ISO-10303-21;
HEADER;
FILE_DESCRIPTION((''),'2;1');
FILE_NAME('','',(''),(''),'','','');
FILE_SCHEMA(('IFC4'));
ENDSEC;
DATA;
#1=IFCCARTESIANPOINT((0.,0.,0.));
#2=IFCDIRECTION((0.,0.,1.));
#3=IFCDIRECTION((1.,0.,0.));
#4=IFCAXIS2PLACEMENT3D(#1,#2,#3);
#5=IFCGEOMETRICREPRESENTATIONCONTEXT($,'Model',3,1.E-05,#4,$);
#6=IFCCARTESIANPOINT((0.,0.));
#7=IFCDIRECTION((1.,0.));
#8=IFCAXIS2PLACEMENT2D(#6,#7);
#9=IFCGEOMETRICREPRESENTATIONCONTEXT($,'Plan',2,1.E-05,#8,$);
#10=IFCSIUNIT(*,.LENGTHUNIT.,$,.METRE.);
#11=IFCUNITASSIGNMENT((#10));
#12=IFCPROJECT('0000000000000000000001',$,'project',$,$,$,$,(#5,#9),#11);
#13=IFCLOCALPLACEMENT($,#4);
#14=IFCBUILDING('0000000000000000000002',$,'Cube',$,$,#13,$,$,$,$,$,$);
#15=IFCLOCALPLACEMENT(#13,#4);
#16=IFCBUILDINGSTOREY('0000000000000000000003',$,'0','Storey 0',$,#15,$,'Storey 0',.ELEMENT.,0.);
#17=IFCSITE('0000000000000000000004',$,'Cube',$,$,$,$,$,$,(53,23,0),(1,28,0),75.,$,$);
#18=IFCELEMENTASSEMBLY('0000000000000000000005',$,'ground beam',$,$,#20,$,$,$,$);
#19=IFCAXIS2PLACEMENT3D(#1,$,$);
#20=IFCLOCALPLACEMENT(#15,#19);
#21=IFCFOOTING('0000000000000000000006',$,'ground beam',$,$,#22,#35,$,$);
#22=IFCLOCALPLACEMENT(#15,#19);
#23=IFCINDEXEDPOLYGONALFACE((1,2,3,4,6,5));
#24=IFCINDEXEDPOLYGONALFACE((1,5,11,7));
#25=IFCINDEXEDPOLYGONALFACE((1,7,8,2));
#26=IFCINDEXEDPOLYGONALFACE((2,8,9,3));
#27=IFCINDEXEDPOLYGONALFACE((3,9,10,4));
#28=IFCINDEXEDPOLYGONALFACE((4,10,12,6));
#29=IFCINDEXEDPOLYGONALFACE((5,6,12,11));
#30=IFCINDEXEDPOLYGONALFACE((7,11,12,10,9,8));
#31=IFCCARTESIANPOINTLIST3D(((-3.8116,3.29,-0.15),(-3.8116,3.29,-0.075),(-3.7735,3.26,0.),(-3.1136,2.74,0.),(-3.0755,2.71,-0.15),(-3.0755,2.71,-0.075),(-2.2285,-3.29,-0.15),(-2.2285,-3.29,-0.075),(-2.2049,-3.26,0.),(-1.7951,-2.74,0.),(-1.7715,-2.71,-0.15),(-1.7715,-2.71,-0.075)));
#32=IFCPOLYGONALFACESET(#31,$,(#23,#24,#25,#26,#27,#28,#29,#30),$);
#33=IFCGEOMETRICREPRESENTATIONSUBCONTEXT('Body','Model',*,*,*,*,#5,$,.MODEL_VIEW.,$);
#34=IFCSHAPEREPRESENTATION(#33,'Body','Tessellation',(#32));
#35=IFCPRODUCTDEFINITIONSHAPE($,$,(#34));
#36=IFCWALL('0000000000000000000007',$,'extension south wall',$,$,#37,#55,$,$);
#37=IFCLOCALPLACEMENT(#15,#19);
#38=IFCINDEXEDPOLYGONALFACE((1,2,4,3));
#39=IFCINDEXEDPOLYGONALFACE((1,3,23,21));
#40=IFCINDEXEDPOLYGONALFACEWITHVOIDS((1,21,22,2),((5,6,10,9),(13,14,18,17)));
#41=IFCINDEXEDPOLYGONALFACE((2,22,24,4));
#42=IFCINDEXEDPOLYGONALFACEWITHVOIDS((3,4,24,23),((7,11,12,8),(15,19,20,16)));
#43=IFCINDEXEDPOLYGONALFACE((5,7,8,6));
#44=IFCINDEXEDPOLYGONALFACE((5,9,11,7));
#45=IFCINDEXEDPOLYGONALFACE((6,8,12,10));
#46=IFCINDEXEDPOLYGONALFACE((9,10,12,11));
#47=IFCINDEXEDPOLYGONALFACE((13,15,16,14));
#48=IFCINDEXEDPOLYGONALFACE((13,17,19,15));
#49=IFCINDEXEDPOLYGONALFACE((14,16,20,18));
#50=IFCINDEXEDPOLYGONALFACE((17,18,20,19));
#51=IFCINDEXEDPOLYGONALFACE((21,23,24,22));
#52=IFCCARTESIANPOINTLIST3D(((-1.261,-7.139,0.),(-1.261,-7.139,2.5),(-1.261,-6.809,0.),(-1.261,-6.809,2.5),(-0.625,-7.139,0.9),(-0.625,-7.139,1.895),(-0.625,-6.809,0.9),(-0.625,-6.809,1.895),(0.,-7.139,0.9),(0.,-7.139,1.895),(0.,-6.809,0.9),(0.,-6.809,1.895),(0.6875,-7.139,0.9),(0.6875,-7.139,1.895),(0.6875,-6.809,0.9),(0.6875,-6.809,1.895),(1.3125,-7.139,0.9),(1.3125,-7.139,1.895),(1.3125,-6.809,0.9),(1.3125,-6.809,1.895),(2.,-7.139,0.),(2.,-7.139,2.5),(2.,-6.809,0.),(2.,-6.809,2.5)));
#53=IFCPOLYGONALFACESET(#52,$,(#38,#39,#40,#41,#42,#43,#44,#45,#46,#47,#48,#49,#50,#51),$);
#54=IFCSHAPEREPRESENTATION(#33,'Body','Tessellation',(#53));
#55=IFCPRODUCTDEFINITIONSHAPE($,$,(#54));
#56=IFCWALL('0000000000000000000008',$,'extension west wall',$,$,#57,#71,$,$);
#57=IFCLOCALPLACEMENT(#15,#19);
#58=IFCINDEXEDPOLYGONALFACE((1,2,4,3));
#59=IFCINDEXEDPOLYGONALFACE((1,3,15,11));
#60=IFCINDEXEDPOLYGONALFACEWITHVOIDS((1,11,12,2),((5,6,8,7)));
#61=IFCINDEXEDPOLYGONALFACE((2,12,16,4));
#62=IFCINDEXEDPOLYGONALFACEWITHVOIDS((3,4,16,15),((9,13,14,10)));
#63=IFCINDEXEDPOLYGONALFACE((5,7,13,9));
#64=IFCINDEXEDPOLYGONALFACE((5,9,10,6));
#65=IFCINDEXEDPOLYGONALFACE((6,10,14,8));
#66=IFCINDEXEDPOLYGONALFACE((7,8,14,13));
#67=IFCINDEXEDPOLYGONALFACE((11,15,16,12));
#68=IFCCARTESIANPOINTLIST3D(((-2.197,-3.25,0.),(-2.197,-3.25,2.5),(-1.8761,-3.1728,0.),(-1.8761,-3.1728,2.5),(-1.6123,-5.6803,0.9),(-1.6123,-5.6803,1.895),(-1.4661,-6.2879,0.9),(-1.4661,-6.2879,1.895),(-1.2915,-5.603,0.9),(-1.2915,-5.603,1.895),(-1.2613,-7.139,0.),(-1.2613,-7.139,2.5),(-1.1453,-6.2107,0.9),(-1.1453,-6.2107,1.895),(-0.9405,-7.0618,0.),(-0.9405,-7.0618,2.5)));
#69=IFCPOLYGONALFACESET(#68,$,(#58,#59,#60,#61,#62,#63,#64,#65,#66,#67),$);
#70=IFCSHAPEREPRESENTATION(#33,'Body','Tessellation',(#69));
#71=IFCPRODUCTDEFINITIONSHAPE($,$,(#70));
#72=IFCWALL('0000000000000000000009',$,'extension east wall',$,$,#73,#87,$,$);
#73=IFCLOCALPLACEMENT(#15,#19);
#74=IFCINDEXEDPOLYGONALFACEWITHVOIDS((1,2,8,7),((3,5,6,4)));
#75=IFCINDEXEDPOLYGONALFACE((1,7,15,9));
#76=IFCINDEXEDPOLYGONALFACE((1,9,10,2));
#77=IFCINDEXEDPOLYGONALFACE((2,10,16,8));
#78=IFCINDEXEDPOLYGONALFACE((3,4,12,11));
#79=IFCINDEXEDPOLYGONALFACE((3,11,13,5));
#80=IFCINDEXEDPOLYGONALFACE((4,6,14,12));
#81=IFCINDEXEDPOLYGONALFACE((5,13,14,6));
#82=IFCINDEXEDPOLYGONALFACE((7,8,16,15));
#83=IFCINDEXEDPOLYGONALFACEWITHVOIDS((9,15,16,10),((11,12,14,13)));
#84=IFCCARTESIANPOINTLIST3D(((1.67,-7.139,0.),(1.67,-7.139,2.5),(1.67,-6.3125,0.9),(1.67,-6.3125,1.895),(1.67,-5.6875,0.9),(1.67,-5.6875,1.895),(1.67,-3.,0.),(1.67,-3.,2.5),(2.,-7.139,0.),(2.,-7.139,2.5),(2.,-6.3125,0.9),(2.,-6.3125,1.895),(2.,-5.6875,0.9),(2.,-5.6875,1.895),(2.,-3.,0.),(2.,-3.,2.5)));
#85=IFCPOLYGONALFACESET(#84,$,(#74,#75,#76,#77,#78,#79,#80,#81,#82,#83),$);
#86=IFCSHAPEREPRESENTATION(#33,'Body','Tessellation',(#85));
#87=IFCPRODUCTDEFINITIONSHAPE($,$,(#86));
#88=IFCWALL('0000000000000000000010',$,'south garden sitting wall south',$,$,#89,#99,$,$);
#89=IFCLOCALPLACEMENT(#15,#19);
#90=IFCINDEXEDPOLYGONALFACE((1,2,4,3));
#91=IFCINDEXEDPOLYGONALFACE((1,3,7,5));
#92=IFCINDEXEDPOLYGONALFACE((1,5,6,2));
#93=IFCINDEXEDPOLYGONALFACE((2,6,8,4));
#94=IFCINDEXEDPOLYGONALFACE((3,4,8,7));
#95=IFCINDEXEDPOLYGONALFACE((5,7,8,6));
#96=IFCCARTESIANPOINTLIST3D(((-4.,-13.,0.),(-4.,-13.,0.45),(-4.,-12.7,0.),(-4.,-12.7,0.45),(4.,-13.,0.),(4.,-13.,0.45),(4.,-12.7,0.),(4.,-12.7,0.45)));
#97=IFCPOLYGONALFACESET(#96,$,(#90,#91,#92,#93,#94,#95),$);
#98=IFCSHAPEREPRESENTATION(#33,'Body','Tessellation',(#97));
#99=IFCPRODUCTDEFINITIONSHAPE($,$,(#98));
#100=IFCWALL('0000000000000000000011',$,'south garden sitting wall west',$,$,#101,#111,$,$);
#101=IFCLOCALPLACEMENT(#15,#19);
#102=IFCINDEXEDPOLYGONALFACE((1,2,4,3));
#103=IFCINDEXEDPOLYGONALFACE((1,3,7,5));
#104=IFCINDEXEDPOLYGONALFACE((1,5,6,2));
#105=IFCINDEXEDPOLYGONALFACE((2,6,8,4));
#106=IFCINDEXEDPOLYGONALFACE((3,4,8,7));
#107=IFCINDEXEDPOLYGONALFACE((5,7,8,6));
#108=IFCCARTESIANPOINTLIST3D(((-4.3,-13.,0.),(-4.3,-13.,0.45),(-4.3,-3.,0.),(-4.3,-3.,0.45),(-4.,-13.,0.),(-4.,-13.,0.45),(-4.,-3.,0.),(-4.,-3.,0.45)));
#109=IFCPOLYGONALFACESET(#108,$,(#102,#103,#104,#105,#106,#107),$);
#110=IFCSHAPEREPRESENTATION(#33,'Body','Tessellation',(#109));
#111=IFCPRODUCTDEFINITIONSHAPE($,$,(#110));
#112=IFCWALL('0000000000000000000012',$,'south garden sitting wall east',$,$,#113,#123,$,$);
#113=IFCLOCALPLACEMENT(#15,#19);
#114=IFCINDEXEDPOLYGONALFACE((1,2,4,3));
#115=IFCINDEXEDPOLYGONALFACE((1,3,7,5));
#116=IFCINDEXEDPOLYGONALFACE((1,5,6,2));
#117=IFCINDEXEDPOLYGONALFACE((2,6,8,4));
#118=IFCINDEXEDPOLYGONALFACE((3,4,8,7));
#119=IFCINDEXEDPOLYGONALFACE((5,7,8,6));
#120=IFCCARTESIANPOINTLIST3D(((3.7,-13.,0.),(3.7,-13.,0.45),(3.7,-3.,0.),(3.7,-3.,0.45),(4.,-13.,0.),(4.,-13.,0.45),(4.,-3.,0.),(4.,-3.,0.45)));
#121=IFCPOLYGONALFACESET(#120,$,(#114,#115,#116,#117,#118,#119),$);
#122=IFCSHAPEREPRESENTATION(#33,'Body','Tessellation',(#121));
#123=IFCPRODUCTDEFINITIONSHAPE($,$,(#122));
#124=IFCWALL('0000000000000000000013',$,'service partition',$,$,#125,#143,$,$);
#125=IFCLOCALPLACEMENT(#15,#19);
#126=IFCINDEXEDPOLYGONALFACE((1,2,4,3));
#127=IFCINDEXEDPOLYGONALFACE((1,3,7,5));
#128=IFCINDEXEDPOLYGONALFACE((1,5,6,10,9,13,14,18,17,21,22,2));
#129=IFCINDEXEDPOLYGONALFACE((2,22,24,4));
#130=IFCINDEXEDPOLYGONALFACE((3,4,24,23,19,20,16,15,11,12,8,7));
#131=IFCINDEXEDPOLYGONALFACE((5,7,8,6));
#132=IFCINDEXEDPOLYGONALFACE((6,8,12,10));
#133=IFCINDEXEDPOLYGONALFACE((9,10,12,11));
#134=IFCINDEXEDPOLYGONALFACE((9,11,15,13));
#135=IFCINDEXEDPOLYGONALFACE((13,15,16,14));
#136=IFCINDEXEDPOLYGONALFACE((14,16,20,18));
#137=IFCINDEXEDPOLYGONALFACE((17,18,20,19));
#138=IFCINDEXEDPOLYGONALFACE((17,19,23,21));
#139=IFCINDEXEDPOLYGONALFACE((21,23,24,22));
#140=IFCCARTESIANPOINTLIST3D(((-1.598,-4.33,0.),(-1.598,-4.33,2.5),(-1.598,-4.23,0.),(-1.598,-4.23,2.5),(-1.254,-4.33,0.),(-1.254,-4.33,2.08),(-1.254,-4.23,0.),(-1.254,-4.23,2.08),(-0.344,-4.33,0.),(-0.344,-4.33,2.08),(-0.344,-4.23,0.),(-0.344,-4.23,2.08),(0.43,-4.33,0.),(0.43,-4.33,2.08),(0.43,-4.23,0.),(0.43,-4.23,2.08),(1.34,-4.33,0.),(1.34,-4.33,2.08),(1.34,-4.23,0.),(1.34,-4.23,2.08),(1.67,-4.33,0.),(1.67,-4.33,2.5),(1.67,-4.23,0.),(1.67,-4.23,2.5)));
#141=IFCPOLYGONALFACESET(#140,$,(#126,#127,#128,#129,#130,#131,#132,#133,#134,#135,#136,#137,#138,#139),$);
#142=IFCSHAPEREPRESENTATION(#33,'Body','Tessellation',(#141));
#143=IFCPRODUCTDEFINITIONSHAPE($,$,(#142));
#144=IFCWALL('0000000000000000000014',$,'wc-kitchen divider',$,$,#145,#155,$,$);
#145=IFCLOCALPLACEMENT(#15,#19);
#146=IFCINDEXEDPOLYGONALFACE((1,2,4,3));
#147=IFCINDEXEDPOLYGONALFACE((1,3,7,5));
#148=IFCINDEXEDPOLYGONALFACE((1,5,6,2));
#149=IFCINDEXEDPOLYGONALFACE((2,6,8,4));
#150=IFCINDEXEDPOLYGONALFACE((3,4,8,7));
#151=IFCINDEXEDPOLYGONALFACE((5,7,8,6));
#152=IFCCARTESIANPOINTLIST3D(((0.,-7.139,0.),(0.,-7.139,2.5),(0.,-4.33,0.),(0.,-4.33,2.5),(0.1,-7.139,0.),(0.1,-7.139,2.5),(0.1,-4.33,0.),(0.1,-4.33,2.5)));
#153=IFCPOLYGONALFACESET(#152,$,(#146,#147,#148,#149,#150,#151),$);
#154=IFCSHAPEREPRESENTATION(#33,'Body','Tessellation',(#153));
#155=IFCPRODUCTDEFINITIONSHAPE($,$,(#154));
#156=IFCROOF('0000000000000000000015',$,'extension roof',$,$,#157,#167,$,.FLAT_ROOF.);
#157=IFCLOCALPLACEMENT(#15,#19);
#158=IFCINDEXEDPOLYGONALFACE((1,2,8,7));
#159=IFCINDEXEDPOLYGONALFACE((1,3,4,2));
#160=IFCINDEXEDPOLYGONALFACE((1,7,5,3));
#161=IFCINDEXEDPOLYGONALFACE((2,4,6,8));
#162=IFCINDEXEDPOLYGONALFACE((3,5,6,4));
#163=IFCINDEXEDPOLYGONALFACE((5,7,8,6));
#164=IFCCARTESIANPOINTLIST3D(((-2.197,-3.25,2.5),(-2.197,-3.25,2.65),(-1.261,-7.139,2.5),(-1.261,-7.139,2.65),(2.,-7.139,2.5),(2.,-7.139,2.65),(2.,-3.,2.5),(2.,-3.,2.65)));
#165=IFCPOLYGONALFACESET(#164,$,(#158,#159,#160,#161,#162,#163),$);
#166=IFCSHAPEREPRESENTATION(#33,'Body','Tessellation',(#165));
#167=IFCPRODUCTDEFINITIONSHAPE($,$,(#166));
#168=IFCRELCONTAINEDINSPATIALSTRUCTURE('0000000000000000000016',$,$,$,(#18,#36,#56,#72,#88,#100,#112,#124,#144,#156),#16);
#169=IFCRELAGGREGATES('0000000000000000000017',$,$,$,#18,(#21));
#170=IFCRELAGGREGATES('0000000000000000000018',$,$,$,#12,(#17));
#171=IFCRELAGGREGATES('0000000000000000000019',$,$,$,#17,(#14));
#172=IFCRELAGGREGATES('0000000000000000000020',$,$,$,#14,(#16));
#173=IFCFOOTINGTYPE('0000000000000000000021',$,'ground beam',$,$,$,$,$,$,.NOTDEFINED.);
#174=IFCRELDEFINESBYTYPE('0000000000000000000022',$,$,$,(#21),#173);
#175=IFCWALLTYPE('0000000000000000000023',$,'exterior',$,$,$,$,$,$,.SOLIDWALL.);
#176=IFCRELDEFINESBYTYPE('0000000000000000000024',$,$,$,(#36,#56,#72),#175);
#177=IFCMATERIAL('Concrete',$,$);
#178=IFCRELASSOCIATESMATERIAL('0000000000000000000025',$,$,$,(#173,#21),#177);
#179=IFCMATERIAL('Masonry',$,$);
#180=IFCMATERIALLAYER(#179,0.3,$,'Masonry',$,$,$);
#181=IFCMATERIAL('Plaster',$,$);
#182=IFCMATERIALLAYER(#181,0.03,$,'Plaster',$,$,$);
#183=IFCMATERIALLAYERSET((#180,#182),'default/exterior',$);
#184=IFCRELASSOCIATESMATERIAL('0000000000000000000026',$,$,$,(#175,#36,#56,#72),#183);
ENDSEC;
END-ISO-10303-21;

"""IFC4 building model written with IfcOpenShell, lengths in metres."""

from ifc_helpers import new_model, si_unit, frame, origin_with_axes, origin_2d_with_axis, place, context, subcontext, project, spatial, polyline, indexed_curve, outline, extrude, clip, halfspace, material, layer, layer_set, layer_usage, material_profile, profile_set, profile_usage, type_object, element, aggregate, save


model = new_model("IFC4")

# Units and contexts
model_context = context("Model", 3, precision=1e-05, world=origin_with_axes())
plan_context = context("Plan", 2, precision=1e-05, world=origin_2d_with_axis())
body_context_1 = subcontext(model_context, "Body", "Model", "MODEL_VIEW")
ifc_project = project(units=[si_unit("LENGTHUNIT", "METRE")], contexts=[model_context, plan_context])

# Site, building, storey
site = spatial("IfcSite", under=ifc_project, Name="Cube", RefLatitude=(53, 23, 0), RefLongitude=(1, 28, 0), RefElevation=75.0)
building_placement = place(None, origin_with_axes())
building = spatial("IfcBuilding", under=site, at=building_placement, Name="Cube")
storey_placement = place(building_placement, origin_with_axes())
storey = spatial("IfcBuildingStorey", under=building, at=storey_placement, Name="0", Description="Storey 0", LongName="Storey 0", CompositionType="ELEMENT", Elevation=0.0)

# Element assembly, footing
assembly_placement = place(storey_placement, origin_with_axes())
assembly = element("IfcElementAssembly", 1, at=assembly_placement, inside=storey, Name="ground beam")
ifc_material_1 = material(Name="Concrete")
ifc_material_profile = material_profile(ifc_material_1, outline(polyline([(-0.26, 0.0), (-0.29, -0.075), (-0.29, -0.15), (0.29, -0.15), (0.29, -0.075), (0.26, 0.0), (-0.26, 0.0)])))
ifc_profile_set = profile_set([ifc_material_profile])
ifc_profile_usage = profile_usage(ifc_profile_set)
footing_type = type_object("IfcFootingType", Name="ground beam", PredefinedType="NOTDEFINED", material=ifc_profile_set)
footing_placement = place(assembly_placement, frame((-1.7661, -3.9723, 0.0), z_axis=(-0.233915, 0.972257, 0.0), x_axis=(-0.972257, -0.233915, 0.0)))
footing = element("IfcFooting", 2, at=footing_placement, type_object=footing_type, material=ifc_profile_usage, Name="ground beam", context=body_context_1, shape_type="Clipping", body=[
    clip(clip(extrude(outline(polyline([(-0.26, 0.0), (-0.29, -0.075), (-0.29, -0.15), (0.29, -0.15), (0.29, -0.075), (0.26, 0.0), (-0.26, 0.0)])), origin_with_axes(), (0.0, 0.0, 1.0), 8.1712), halfspace(frame((0.0, 0.0, 1.0), z_axis=(-0.618904, 0.0, -0.785467), x_axis=(0.0, 1.0, 0.0)), False)), halfspace(frame((0.0, 0.0, 7.1712), z_axis=(-0.785467, 0.0, 0.618904), x_axis=(0.0, 1.0, 0.0)), False)),
])
aggregate(assembly, [footing])

# Wall, openings
ifc_material_2 = material(Name="Masonry")
ifc_layer_1 = layer(ifc_material_2, 0.3, Name="Masonry")
ifc_material_3 = material(Name="Plaster")
ifc_layer_2 = layer(ifc_material_3, 0.03, Name="Plaster")
ifc_layer_set = layer_set([ifc_layer_1, ifc_layer_2], Name="default/exterior")
ifc_layer_usage = layer_usage(ifc_layer_set, "AXIS2", "POSITIVE", 0.0)
wall_type = type_object("IfcWallType", Name="exterior", PredefinedType="SOLIDWALL", material=ifc_layer_set)
wall_1_placement = place(storey_placement, frame((-1.261, -7.139, 0.0), z_axis=(0.0, 0.0, 1.0), x_axis=(1.0, 0.0, 0.0)))
wall_1 = element("IfcWall", 3, at=wall_1_placement, inside=storey, type_object=wall_type, material=ifc_layer_usage, Name="extension south wall", context=body_context_1, shape_type="SweptSolid", body=[
    extrude(outline(indexed_curve([(0.0, 0.0), (0.0, 0.33), (3.261, 0.33), (3.261, 0.0), (0.0, 0.0)], self_intersect=False)), origin_with_axes(), (0.0, 0.0, 1.0), 2.5),
])
opening_1_placement = place(wall_1_placement, frame((0.636, 0.0, 0.9), z_axis=(0.0, 0.0, 1.0), x_axis=(1.0, 0.0, 0.0)))
element("IfcOpeningElement", 4, at=opening_1_placement, cuts=wall_1, PredefinedType="OPENING", context=body_context_1, shape_type="SweptSolid", body=[
    extrude(outline(indexed_curve([(0.0, 0.0), (0.0, 0.5), (0.625, 0.5), (0.625, 0.0), (0.0, 0.0)], self_intersect=False)), origin_with_axes(), (0.0, 0.0, 1.0), 0.995),
])
opening_2_placement = place(wall_1_placement, frame((1.9485, 0.0, 0.9), z_axis=(0.0, 0.0, 1.0), x_axis=(1.0, 0.0, 0.0)))
element("IfcOpeningElement", 5, at=opening_2_placement, cuts=wall_1, PredefinedType="OPENING", context=body_context_1, shape_type="SweptSolid", body=[
    extrude(outline(indexed_curve([(0.0, 0.0), (0.0, 0.5), (0.625, 0.5), (0.625, 0.0), (0.0, 0.0)], self_intersect=False)), origin_with_axes(), (0.0, 0.0, 1.0), 0.995),
])

# Walls, openings
wall_2_placement = place(storey_placement, frame((-2.197, -3.25, 0.0), z_axis=(0.0, 0.0, 1.0), x_axis=(0.233916, -0.972257, 0.0)))
wall_2 = element("IfcWall", 6, at=wall_2_placement, inside=storey, type_object=wall_type, material=ifc_layer_usage, Name="extension west wall", context=body_context_1, shape_type="SweptSolid", body=[
    extrude(outline(indexed_curve([(0.0, 0.0), (0.0, 0.33), (4.0, 0.33), (4.0, 0.0), (0.0, 0.0)], self_intersect=False)), origin_with_axes(), (0.0, 0.0, 1.0), 2.5),
])
opening_3_placement = place(wall_2_placement, frame((2.4996, -0.0501, 0.9), z_axis=(0.0, 0.0, 1.0), x_axis=(1.0, 0.000142, 0.0)))
element("IfcOpeningElement", 7, at=opening_3_placement, cuts=wall_2, PredefinedType="OPENING", context=body_context_1, shape_type="SweptSolid", body=[
    extrude(outline(indexed_curve([(0.0, 0.0), (0.0, 0.43), (0.625, 0.43), (0.625, 0.0), (0.0, 0.0)], self_intersect=False)), origin_with_axes(), (0.0, 0.0, 1.0), 0.995),
])
wall_3_placement = place(storey_placement, frame((2.0, -7.139, 0.0), z_axis=(0.0, 0.0, 1.0), x_axis=(0.0, 1.0, 0.0)))
wall_3 = element("IfcWall", 8, at=wall_3_placement, inside=storey, type_object=wall_type, material=ifc_layer_usage, Name="extension east wall", context=body_context_1, shape_type="SweptSolid", body=[
    extrude(outline(indexed_curve([(0.0, 0.0), (0.0, 0.33), (4.139, 0.33), (4.139, 0.0), (0.0, 0.0)], self_intersect=False)), origin_with_axes(), (0.0, 0.0, 1.0), 2.5),
])
opening_4_placement = place(wall_3_placement, frame((0.8265, 0.0, 0.9), z_axis=(0.0, 0.0, 1.0), x_axis=(1.0, 0.0, 0.0)))
element("IfcOpeningElement", 9, at=opening_4_placement, cuts=wall_3, PredefinedType="OPENING", context=body_context_1, shape_type="SweptSolid", body=[
    extrude(outline(indexed_curve([(0.0, 0.0), (0.0, 0.5), (0.625, 0.5), (0.625, 0.0), (0.0, 0.0)], self_intersect=False)), origin_with_axes(), (0.0, 0.0, 1.0), 0.995),
])

# Walls
wall_4_placement = place(storey_placement, frame((-4.0, -13.0, 0.0), z_axis=(0.0, 0.0, 1.0), x_axis=(1.0, 0.0, 0.0)))
element("IfcWall", 10, at=wall_4_placement, inside=storey, Name="south garden sitting wall south", context=body_context_1, shape_type="SweptSolid", body=[
    extrude(outline(indexed_curve([(0.0, 0.0), (0.0, 0.3), (8.0, 0.3), (8.0, 0.0), (0.0, 0.0)], self_intersect=False)), origin_with_axes(), (0.0, 0.0, 1.0), 0.45),
])
for number, where, z_axis, x_axis, name in (
    (11, (-4.0, -13.0, 0.0), (0.0, 0.0, 1.0), (0.0, 1.0, 0.0), "south garden sitting wall west"),
    (12, (4.0, -13.0, 0.0), (0.0, 0.0, 1.0), (0.0, 1.0, 0.0), "south garden sitting wall east"),
):
    element("IfcWall", number, at=place(storey_placement, frame(where, z_axis=z_axis, x_axis=x_axis)), inside=storey, Name=name, context=body_context_1, shape_type="SweptSolid", body=[
        extrude(outline(indexed_curve([(0.0, 0.0), (0.0, 0.3), (10.0, 0.3), (10.0, 0.0), (0.0, 0.0)], self_intersect=False)), origin_with_axes(), (0.0, 0.0, 1.0), 0.45),
    ])

# Wall, openings
wall_5_placement = place(storey_placement, frame((-1.598, -4.33, 0.0), z_axis=(0.0, 0.0, 1.0), x_axis=(1.0, 0.0, 0.0)))
wall_5 = element("IfcWall", 13, at=wall_5_placement, inside=storey, Name="service partition", context=body_context_1, shape_type="SweptSolid", body=[
    extrude(outline(indexed_curve([(0.0, 0.0), (0.0, 0.1), (3.268, 0.1), (3.268, 0.0), (0.0, 0.0)], self_intersect=False)), origin_with_axes(), (0.0, 0.0, 1.0), 2.5),
])
opening_5_placement = place(wall_5_placement, frame((0.344, -0.05, 0.0), z_axis=(0.0, 0.0, 1.0), x_axis=(1.0, 0.0, 0.0)))
element("IfcOpeningElement", 14, at=opening_5_placement, cuts=wall_5, context=body_context_1, shape_type="SweptSolid", body=[
    extrude(outline(indexed_curve([(0.0, 0.0), (0.0, 0.3), (0.91, 0.3), (0.91, 0.0), (0.0, 0.0)], self_intersect=False)), origin_with_axes(), (0.0, 0.0, 1.0), 2.08),
])
opening_6_placement = place(wall_5_placement, frame((2.028, -0.05, 0.0), z_axis=(0.0, 0.0, 1.0), x_axis=(1.0, 0.0, 0.0)))
element("IfcOpeningElement", 15, at=opening_6_placement, cuts=wall_5, context=body_context_1, shape_type="SweptSolid", body=[
    extrude(outline(indexed_curve([(0.0, 0.0), (0.0, 0.3), (0.91, 0.3), (0.91, 0.0), (0.0, 0.0)], self_intersect=False)), origin_with_axes(), (0.0, 0.0, 1.0), 2.08),
])

# Wall
wall_6_placement = place(storey_placement, frame((0.0, -4.33, 0.0), z_axis=(0.0, 0.0, 1.0), x_axis=(0.0, -1.0, 0.0)))
element("IfcWall", 16, at=wall_6_placement, inside=storey, Name="wc-kitchen divider", context=body_context_1, shape_type="SweptSolid", body=[
    extrude(outline(indexed_curve([(0.0, 0.0), (0.0, 0.1), (2.809, 0.1), (2.809, 0.0), (0.0, 0.0)], self_intersect=False)), origin_with_axes(), (0.0, 0.0, 1.0), 2.5),
])

# Roof
roof_placement = place(storey_placement, frame((-1.261, -7.139, 2.5), z_axis=(0.0, 0.0, 1.0), x_axis=(1.0, 0.0, 0.0)))
element("IfcRoof", 17, at=roof_placement, inside=storey, Name="extension roof", PredefinedType="FLAT_ROOF", context=body_context_1, shape_type="SweptSolid", body=[
    extrude(outline(indexed_curve([(0.0, 0.0), (3.261, 0.0), (3.261, 4.139), (-0.936, 3.889)])), None, (0.0, 0.0, 1.0), 0.15),
])

save(model, "model.ifc")
